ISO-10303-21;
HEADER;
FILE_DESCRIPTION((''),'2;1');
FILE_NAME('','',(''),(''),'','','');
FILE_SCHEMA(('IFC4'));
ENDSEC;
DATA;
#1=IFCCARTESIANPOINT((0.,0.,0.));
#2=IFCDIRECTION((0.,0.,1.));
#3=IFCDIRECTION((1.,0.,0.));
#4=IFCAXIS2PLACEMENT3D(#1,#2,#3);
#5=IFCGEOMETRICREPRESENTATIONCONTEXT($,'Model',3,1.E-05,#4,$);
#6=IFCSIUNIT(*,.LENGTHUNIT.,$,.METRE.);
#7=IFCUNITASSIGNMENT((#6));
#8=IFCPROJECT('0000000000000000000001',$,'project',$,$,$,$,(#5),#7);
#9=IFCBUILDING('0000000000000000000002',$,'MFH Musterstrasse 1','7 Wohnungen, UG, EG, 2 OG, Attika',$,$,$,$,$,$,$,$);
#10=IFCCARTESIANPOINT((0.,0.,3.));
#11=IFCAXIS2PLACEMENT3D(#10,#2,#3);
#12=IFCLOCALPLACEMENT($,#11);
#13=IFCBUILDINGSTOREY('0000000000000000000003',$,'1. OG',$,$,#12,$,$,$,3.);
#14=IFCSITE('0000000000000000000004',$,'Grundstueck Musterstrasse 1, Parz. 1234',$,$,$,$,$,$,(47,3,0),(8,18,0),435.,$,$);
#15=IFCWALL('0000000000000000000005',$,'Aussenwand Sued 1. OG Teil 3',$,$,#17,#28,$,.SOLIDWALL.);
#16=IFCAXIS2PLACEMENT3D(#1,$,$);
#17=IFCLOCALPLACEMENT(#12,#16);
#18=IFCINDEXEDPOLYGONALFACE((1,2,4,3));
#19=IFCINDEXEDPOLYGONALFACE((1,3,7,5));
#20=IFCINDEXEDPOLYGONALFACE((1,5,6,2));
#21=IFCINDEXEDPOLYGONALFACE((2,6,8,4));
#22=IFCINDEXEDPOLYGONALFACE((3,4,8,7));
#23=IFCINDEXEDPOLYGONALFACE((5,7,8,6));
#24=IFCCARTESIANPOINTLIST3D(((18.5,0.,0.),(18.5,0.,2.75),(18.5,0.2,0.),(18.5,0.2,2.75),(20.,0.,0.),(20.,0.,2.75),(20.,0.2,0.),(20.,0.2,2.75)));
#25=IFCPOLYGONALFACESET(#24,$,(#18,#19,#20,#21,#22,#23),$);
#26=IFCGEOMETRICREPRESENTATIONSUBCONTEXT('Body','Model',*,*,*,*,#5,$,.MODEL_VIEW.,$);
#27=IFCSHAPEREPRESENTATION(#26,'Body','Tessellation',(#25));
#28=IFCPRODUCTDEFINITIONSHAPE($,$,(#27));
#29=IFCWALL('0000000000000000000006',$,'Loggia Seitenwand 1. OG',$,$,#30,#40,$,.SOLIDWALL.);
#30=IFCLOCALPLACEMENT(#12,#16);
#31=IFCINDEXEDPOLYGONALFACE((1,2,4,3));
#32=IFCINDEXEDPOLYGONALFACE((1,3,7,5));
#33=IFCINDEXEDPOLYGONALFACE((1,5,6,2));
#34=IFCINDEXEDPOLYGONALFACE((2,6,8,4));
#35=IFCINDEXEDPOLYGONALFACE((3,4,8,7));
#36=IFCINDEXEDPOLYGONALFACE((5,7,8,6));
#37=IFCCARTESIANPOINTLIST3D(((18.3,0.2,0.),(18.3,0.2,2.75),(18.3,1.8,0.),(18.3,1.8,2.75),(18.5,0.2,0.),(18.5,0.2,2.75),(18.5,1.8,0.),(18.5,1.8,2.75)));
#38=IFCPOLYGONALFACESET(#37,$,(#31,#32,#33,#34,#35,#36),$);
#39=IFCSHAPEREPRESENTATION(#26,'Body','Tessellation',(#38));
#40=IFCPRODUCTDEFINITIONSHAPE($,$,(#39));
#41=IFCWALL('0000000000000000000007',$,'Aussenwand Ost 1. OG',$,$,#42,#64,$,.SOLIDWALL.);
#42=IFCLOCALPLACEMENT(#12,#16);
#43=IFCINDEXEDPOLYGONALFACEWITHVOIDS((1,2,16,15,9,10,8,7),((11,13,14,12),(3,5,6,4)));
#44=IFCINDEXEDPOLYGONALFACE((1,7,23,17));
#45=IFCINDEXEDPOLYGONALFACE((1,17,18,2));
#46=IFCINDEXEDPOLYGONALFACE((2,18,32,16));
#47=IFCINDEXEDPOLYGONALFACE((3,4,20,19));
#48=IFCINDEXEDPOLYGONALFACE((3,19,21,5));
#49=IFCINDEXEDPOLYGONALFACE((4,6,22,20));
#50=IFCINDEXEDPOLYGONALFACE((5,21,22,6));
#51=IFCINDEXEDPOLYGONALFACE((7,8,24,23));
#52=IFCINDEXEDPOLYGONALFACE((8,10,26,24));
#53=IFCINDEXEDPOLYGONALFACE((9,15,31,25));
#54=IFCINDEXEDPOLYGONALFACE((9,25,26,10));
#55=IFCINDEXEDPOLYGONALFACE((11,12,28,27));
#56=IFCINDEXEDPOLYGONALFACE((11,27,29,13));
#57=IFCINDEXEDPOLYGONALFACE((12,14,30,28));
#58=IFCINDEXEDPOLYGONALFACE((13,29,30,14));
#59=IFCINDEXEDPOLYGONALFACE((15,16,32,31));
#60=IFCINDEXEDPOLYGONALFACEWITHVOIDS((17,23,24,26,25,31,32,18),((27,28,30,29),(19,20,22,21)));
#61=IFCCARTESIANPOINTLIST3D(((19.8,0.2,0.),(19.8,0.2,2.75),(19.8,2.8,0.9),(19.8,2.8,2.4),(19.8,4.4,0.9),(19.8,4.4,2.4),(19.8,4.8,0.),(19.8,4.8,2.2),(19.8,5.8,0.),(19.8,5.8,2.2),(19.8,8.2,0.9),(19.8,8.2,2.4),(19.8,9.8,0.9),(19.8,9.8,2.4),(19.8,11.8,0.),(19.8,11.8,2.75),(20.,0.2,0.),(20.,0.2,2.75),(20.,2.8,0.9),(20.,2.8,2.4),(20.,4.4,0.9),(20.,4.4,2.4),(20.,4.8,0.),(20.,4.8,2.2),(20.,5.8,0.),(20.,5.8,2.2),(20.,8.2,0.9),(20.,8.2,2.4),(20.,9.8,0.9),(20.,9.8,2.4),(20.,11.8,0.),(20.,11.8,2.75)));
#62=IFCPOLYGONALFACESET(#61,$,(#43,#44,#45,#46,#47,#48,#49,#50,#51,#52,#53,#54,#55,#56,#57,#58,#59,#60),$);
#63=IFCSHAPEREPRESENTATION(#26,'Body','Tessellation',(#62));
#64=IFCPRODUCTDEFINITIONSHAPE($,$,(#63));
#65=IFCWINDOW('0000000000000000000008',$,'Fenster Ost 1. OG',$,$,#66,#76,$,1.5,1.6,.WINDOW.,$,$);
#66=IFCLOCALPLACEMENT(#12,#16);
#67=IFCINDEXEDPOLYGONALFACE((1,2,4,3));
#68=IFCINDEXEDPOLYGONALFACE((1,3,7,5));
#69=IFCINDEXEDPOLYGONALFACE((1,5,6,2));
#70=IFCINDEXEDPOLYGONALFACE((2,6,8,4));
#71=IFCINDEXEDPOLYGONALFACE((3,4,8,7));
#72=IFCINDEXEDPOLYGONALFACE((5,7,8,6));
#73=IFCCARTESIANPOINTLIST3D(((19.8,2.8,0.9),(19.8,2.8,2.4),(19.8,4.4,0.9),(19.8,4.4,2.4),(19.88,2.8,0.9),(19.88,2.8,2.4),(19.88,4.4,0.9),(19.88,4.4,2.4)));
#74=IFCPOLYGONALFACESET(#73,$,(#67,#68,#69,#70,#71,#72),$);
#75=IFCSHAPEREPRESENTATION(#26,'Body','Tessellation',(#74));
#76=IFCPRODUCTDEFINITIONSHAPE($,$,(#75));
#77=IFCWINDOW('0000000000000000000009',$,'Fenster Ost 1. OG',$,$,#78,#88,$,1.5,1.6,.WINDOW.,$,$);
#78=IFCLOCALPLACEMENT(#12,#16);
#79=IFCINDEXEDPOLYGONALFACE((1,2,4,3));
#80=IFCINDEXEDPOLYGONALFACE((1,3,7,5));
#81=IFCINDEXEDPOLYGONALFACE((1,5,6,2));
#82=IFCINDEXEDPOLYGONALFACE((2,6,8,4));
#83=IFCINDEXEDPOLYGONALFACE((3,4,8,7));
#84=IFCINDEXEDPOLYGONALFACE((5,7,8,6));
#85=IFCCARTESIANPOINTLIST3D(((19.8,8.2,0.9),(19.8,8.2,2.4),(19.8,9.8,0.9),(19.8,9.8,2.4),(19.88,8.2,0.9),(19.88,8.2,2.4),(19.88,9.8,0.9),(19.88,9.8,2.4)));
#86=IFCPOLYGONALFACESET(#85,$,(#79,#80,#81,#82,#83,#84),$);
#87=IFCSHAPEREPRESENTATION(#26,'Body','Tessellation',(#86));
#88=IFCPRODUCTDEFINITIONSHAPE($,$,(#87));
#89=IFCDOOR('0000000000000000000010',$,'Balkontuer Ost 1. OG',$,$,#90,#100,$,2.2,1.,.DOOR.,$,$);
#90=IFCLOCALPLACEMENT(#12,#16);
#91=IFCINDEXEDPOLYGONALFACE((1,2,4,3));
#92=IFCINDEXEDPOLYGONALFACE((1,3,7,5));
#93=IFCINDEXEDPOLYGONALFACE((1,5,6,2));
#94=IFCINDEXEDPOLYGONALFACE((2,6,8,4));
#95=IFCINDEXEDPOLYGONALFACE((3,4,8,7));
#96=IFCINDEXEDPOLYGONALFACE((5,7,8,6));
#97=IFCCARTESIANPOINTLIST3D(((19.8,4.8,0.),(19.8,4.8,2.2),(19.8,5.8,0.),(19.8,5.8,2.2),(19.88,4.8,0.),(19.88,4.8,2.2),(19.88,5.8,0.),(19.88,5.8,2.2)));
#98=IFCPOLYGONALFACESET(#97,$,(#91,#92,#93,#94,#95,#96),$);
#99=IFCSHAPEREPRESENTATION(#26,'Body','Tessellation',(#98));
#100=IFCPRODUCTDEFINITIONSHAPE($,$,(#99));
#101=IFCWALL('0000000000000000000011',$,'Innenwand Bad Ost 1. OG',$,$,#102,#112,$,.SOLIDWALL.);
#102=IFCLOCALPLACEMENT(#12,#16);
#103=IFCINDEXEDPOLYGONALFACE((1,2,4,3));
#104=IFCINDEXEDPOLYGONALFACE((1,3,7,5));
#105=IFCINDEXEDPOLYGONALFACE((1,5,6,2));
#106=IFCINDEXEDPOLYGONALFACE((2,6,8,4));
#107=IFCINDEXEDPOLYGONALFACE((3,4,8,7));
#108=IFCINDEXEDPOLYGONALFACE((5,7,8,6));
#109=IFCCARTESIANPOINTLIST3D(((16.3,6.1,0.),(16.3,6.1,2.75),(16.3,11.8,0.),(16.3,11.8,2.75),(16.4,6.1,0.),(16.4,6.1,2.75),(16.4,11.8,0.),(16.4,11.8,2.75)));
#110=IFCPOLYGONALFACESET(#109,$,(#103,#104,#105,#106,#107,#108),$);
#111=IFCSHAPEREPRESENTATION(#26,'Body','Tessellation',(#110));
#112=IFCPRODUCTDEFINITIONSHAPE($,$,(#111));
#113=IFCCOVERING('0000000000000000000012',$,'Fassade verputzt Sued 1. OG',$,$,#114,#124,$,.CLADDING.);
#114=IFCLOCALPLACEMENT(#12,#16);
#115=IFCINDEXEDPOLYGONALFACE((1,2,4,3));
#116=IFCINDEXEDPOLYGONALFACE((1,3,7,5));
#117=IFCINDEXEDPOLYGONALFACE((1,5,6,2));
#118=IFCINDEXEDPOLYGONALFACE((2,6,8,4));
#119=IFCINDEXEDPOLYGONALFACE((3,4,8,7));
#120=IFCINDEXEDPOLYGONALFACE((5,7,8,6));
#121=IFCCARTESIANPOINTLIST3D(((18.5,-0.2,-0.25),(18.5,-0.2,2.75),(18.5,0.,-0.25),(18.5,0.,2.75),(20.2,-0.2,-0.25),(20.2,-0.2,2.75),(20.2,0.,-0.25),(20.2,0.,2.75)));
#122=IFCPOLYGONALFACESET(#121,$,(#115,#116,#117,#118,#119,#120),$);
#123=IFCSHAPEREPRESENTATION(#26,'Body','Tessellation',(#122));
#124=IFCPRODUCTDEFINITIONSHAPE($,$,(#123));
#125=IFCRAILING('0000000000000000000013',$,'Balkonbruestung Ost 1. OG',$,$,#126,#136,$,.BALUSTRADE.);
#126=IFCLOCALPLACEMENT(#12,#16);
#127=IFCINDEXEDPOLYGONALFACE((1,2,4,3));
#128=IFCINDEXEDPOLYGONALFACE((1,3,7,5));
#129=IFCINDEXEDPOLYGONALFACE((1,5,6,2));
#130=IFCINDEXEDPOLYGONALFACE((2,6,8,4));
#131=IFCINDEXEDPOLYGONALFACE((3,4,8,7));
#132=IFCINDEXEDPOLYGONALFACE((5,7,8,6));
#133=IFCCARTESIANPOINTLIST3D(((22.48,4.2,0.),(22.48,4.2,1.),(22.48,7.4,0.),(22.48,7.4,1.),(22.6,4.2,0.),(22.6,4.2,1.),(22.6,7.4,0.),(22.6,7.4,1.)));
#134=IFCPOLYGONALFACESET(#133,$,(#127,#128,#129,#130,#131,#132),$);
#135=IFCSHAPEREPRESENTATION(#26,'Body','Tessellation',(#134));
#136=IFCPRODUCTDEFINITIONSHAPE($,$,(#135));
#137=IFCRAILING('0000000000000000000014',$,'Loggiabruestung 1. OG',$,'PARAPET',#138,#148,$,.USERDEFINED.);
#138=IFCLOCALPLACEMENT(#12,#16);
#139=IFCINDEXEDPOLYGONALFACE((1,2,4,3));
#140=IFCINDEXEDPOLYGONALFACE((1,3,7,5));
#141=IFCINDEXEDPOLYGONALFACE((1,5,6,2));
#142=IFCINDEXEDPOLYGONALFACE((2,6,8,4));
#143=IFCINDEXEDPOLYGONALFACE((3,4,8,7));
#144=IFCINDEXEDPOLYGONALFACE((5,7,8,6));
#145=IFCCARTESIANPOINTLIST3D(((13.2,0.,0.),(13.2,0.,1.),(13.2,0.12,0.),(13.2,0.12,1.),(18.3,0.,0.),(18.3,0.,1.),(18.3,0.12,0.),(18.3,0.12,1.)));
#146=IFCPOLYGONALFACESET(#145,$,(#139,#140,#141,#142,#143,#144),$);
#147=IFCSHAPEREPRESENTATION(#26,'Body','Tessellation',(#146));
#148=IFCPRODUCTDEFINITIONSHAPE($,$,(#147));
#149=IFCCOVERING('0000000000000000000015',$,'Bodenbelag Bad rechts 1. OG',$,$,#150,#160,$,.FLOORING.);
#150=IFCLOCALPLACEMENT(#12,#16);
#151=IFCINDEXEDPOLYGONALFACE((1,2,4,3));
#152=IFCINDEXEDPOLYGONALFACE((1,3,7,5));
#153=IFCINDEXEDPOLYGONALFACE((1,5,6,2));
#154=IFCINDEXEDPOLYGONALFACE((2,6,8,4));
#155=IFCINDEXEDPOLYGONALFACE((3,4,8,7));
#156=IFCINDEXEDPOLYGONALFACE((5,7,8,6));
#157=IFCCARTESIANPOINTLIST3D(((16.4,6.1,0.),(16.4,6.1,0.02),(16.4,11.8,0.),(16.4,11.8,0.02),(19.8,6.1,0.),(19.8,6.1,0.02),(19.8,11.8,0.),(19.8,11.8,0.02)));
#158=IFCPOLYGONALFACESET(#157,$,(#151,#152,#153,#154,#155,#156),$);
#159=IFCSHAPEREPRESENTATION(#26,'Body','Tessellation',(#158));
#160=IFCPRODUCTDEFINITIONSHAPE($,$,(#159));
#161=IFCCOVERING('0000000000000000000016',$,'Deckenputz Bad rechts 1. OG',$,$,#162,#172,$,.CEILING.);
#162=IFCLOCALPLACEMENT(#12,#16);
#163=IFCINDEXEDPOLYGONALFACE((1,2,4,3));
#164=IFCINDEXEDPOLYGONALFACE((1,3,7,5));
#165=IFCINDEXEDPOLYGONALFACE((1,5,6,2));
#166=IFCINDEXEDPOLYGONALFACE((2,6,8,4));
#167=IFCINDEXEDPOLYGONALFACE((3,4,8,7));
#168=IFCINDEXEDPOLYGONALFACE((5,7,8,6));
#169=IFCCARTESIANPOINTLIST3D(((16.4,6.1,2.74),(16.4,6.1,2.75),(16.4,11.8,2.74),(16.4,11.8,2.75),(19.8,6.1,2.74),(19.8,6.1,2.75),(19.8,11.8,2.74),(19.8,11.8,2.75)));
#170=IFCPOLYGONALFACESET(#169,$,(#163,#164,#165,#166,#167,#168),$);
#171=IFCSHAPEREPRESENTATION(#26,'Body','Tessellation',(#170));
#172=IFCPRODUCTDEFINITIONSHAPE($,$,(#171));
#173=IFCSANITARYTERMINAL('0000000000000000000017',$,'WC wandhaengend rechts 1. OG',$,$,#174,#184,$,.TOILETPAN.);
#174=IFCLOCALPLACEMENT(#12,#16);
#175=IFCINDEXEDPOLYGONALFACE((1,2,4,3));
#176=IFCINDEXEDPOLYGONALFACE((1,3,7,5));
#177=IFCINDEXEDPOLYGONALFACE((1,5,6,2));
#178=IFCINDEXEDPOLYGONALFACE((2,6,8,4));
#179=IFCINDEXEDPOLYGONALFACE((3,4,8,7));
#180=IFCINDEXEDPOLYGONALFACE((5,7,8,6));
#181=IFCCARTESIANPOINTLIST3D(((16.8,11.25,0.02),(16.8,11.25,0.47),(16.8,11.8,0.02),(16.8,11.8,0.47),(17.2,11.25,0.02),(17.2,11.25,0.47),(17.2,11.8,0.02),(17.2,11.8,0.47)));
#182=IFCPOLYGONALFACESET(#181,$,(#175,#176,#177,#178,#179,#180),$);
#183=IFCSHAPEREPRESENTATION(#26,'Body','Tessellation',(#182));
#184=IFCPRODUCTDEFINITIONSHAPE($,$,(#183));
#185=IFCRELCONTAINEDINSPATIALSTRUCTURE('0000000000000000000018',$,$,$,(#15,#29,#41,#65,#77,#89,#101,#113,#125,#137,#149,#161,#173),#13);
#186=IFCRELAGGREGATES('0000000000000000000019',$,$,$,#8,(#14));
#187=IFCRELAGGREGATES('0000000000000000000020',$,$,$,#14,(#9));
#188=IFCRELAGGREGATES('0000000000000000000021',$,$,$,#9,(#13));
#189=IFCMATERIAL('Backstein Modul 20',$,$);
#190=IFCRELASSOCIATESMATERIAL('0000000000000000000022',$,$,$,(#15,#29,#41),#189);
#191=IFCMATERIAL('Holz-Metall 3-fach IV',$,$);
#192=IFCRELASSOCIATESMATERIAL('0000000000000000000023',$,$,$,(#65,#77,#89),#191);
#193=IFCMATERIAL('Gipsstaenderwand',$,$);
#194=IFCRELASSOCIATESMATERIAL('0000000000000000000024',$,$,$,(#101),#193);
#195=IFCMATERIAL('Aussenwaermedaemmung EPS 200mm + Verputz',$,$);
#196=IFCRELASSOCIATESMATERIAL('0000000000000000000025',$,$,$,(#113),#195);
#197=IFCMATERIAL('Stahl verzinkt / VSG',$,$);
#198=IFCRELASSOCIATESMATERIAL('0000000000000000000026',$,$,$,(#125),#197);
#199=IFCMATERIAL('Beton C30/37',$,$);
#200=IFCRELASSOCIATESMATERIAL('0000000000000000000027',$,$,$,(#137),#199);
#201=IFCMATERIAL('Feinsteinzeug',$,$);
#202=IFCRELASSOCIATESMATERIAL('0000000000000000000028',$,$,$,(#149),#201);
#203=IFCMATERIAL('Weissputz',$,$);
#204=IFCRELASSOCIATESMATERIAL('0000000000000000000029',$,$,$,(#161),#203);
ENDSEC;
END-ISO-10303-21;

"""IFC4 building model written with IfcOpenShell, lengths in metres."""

from ifc_helpers import new_model, si_unit, frame, frame_2d, origin_with_axes, place, context, subcontext, project, spatial, rectangle, extrude, material, element, fill, save


model = new_model("IFC4")

# Units and contexts
model_context = context("Model", 3, precision=1e-05, world=origin_with_axes())
body_context = subcontext(model_context, "Body", "Model", "MODEL_VIEW")
ifc_project = project(units=[si_unit("LENGTHUNIT", "METRE")], contexts=[model_context])

# Site, building, storey
site = spatial("IfcSite", under=ifc_project, Name="Grundstueck Musterstrasse 1, Parz. 1234", RefLatitude=(47, 3, 0), RefLongitude=(8, 18, 0), RefElevation=435.0)
building = spatial("IfcBuilding", under=site, Name="MFH Musterstrasse 1", Description="7 Wohnungen, UG, EG, 2 OG, Attika")
storey_placement = place(None, frame((0.0, 0.0, 3.0), z_axis=(0.0, 0.0, 1.0), x_axis=(1.0, 0.0, 0.0)))
storey = spatial("IfcBuildingStorey", under=building, at=storey_placement, Name="1. OG", Elevation=3.0)

# Walls
ifc_material_1 = material(Name="Backstein Modul 20")
wall_1_placement = place(storey_placement, frame((18.5, 0.0, 0.0), z_axis=(0.0, 0.0, 1.0), x_axis=(1.0, 0.0, 0.0)))
element("IfcWall", 1, at=wall_1_placement, inside=storey, material=ifc_material_1, Name="Aussenwand Sued 1. OG Teil 3", PredefinedType="SOLIDWALL", context=body_context, shape_type="SweptSolid", body=[
    extrude(rectangle(XDim=1.5, YDim=0.2, at=frame_2d((0.75, 0.1))), origin_with_axes(), (0.0, 0.0, 1.0), 2.75),
])
wall_2_placement = place(storey_placement, frame((18.3, 0.2, 0.0), z_axis=(0.0, 0.0, 1.0), x_axis=(1.0, 0.0, 0.0)))
element("IfcWall", 2, at=wall_2_placement, inside=storey, material=ifc_material_1, Name="Loggia Seitenwand 1. OG", PredefinedType="SOLIDWALL", context=body_context, shape_type="SweptSolid", body=[
    extrude(rectangle(XDim=0.2, YDim=1.6, at=frame_2d((0.1, 0.8))), origin_with_axes(), (0.0, 0.0, 1.0), 2.75),
])

# Wall, openings, windows, door
wall_3_placement = place(storey_placement, frame((19.8, 0.2, 0.0), z_axis=(0.0, 0.0, 1.0), x_axis=(1.0, 0.0, 0.0)))
wall_3 = element("IfcWall", 3, at=wall_3_placement, inside=storey, material=ifc_material_1, Name="Aussenwand Ost 1. OG", PredefinedType="SOLIDWALL", context=body_context, shape_type="SweptSolid", body=[
    extrude(rectangle(XDim=0.2, YDim=11.6, at=frame_2d((0.1, 5.8))), origin_with_axes(), (0.0, 0.0, 1.0), 2.75),
])
opening_1_placement = place(wall_3_placement, frame((-0.01, 2.6, 0.9), z_axis=(0.0, 0.0, 1.0), x_axis=(1.0, 0.0, 0.0)))
opening_1 = element("IfcOpeningElement", 4, at=opening_1_placement, cuts=wall_3, context=body_context, shape_type="SweptSolid", body=[
    extrude(rectangle(XDim=0.42, YDim=1.6, at=frame_2d((0.21, 0.8))), origin_with_axes(), (0.0, 0.0, 1.0), 1.5),
])
opening_2_placement = place(wall_3_placement, frame((-0.01, 8.0, 0.9), z_axis=(0.0, 0.0, 1.0), x_axis=(1.0, 0.0, 0.0)))
opening_2 = element("IfcOpeningElement", 5, at=opening_2_placement, cuts=wall_3, context=body_context, shape_type="SweptSolid", body=[
    extrude(rectangle(XDim=0.42, YDim=1.6, at=frame_2d((0.21, 0.8))), origin_with_axes(), (0.0, 0.0, 1.0), 1.5),
])
opening_3_placement = place(wall_3_placement, frame((-0.01, 4.6, 0.0), z_axis=(0.0, 0.0, 1.0), x_axis=(1.0, 0.0, 0.0)))
opening_3 = element("IfcOpeningElement", 6, at=opening_3_placement, cuts=wall_3, context=body_context, shape_type="SweptSolid", body=[
    extrude(rectangle(XDim=0.42, YDim=1.0, at=frame_2d((0.21, 0.5))), origin_with_axes(), (0.0, 0.0, 1.0), 2.2),
])
ifc_material_2 = material(Name="Holz-Metall 3-fach IV")
window_1_placement = place(storey_placement, frame((19.8, 2.8, 0.9), z_axis=(0.0, 0.0, 1.0), x_axis=(1.0, 0.0, 0.0)))
window_1 = element("IfcWindow", 7, at=window_1_placement, inside=storey, material=ifc_material_2, Name="Fenster Ost 1. OG", OverallHeight=1.5, OverallWidth=1.6, PredefinedType="WINDOW", context=body_context, shape_type="SweptSolid", body=[
    extrude(rectangle(XDim=0.08, YDim=1.6, at=frame_2d((0.04, 0.8))), origin_with_axes(), (0.0, 0.0, 1.0), 1.5),
])
fill(opening_1, window_1)
window_2_placement = place(storey_placement, frame((19.8, 8.2, 0.9), z_axis=(0.0, 0.0, 1.0), x_axis=(1.0, 0.0, 0.0)))
window_2 = element("IfcWindow", 8, at=window_2_placement, inside=storey, material=ifc_material_2, Name="Fenster Ost 1. OG", OverallHeight=1.5, OverallWidth=1.6, PredefinedType="WINDOW", context=body_context, shape_type="SweptSolid", body=[
    extrude(rectangle(XDim=0.08, YDim=1.6, at=frame_2d((0.04, 0.8))), origin_with_axes(), (0.0, 0.0, 1.0), 1.5),
])
fill(opening_2, window_2)
door_placement = place(storey_placement, frame((19.8, 4.8, 0.0), z_axis=(0.0, 0.0, 1.0), x_axis=(1.0, 0.0, 0.0)))
door = element("IfcDoor", 9, at=door_placement, inside=storey, material=ifc_material_2, Name="Balkontuer Ost 1. OG", OverallHeight=2.2, OverallWidth=1.0, PredefinedType="DOOR", context=body_context, shape_type="SweptSolid", body=[
    extrude(rectangle(XDim=0.08, YDim=1.0, at=frame_2d((0.04, 0.5))), origin_with_axes(), (0.0, 0.0, 1.0), 2.2),
])
fill(opening_3, door)

# Wall
ifc_material_3 = material(Name="Gipsstaenderwand")
wall_4_placement = place(storey_placement, frame((16.3, 6.1, 0.0), z_axis=(0.0, 0.0, 1.0), x_axis=(1.0, 0.0, 0.0)))
element("IfcWall", 10, at=wall_4_placement, inside=storey, material=ifc_material_3, Name="Innenwand Bad Ost 1. OG", PredefinedType="SOLIDWALL", context=body_context, shape_type="SweptSolid", body=[
    extrude(rectangle(XDim=0.1, YDim=5.7, at=frame_2d((0.05, 2.85))), origin_with_axes(), (0.0, 0.0, 1.0), 2.75),
])

# Shared definitions
ifc_material_4 = material(Name="Aussenwaermedaemmung EPS 200mm + Verputz")

# Covering
covering_1_placement = place(storey_placement, frame((18.5, -0.2, -0.25), z_axis=(0.0, 0.0, 1.0), x_axis=(1.0, 0.0, 0.0)))
element("IfcCovering", 11, at=covering_1_placement, inside=storey, material=ifc_material_4, Name="Fassade verputzt Sued 1. OG", PredefinedType="CLADDING", context=body_context, shape_type="SweptSolid", body=[
    extrude(rectangle(XDim=1.7, YDim=0.2, at=frame_2d((0.85, 0.1))), origin_with_axes(), (0.0, 0.0, 1.0), 3.0),
])

# Railings
ifc_material_5 = material(Name="Stahl verzinkt / VSG")
railing_1_placement = place(storey_placement, frame((22.48, 4.2, 0.0), z_axis=(0.0, 0.0, 1.0), x_axis=(1.0, 0.0, 0.0)))
element("IfcRailing", 12, at=railing_1_placement, inside=storey, material=ifc_material_5, Name="Balkonbruestung Ost 1. OG", PredefinedType="BALUSTRADE", context=body_context, shape_type="SweptSolid", body=[
    extrude(rectangle(XDim=0.12, YDim=3.2, at=frame_2d((0.06, 1.6))), origin_with_axes(), (0.0, 0.0, 1.0), 1.0),
])
ifc_material_6 = material(Name="Beton C30/37")
railing_2_placement = place(storey_placement, frame((13.2, 0.0, 0.0), z_axis=(0.0, 0.0, 1.0), x_axis=(1.0, 0.0, 0.0)))
element("IfcRailing", 13, at=railing_2_placement, inside=storey, material=ifc_material_6, Name="Loggiabruestung 1. OG", ObjectType="PARAPET", PredefinedType="USERDEFINED", context=body_context, shape_type="SweptSolid", body=[
    extrude(rectangle(XDim=5.1, YDim=0.12, at=frame_2d((2.55, 0.06))), origin_with_axes(), (0.0, 0.0, 1.0), 1.0),
])

# Coverings
ifc_material_7 = material(Name="Feinsteinzeug")
covering_2_placement = place(storey_placement, frame((16.4, 6.1, 0.0), z_axis=(0.0, 0.0, 1.0), x_axis=(1.0, 0.0, 0.0)))
element("IfcCovering", 14, at=covering_2_placement, inside=storey, material=ifc_material_7, Name="Bodenbelag Bad rechts 1. OG", PredefinedType="FLOORING", context=body_context, shape_type="SweptSolid", body=[
    extrude(rectangle(XDim=3.4, YDim=5.7, at=frame_2d((1.7, 2.85))), origin_with_axes(), (0.0, 0.0, 1.0), 0.02),
])
ifc_material_8 = material(Name="Weissputz")
covering_3_placement = place(storey_placement, frame((16.4, 6.1, 2.74), z_axis=(0.0, 0.0, 1.0), x_axis=(1.0, 0.0, 0.0)))
element("IfcCovering", 15, at=covering_3_placement, inside=storey, material=ifc_material_8, Name="Deckenputz Bad rechts 1. OG", PredefinedType="CEILING", context=body_context, shape_type="SweptSolid", body=[
    extrude(rectangle(XDim=3.4, YDim=5.7, at=frame_2d((1.7, 2.85))), origin_with_axes(), (0.0, 0.0, 1.0), 0.01),
])

# Sanitary terminal
sanitary_terminal_1_placement = place(storey_placement, frame((16.8, 11.25, 0.02), z_axis=(0.0, 0.0, 1.0), x_axis=(1.0, 0.0, 0.0)))
element("IfcSanitaryTerminal", 16, at=sanitary_terminal_1_placement, inside=storey, Name="WC wandhaengend rechts 1. OG", PredefinedType="TOILETPAN", context=body_context, shape_type="SweptSolid", body=[
    extrude(rectangle(XDim=0.4, YDim=0.55, at=frame_2d((0.2, 0.275))), origin_with_axes(), (0.0, 0.0, 1.0), 0.45),
])

save(model, "model.ifc")
